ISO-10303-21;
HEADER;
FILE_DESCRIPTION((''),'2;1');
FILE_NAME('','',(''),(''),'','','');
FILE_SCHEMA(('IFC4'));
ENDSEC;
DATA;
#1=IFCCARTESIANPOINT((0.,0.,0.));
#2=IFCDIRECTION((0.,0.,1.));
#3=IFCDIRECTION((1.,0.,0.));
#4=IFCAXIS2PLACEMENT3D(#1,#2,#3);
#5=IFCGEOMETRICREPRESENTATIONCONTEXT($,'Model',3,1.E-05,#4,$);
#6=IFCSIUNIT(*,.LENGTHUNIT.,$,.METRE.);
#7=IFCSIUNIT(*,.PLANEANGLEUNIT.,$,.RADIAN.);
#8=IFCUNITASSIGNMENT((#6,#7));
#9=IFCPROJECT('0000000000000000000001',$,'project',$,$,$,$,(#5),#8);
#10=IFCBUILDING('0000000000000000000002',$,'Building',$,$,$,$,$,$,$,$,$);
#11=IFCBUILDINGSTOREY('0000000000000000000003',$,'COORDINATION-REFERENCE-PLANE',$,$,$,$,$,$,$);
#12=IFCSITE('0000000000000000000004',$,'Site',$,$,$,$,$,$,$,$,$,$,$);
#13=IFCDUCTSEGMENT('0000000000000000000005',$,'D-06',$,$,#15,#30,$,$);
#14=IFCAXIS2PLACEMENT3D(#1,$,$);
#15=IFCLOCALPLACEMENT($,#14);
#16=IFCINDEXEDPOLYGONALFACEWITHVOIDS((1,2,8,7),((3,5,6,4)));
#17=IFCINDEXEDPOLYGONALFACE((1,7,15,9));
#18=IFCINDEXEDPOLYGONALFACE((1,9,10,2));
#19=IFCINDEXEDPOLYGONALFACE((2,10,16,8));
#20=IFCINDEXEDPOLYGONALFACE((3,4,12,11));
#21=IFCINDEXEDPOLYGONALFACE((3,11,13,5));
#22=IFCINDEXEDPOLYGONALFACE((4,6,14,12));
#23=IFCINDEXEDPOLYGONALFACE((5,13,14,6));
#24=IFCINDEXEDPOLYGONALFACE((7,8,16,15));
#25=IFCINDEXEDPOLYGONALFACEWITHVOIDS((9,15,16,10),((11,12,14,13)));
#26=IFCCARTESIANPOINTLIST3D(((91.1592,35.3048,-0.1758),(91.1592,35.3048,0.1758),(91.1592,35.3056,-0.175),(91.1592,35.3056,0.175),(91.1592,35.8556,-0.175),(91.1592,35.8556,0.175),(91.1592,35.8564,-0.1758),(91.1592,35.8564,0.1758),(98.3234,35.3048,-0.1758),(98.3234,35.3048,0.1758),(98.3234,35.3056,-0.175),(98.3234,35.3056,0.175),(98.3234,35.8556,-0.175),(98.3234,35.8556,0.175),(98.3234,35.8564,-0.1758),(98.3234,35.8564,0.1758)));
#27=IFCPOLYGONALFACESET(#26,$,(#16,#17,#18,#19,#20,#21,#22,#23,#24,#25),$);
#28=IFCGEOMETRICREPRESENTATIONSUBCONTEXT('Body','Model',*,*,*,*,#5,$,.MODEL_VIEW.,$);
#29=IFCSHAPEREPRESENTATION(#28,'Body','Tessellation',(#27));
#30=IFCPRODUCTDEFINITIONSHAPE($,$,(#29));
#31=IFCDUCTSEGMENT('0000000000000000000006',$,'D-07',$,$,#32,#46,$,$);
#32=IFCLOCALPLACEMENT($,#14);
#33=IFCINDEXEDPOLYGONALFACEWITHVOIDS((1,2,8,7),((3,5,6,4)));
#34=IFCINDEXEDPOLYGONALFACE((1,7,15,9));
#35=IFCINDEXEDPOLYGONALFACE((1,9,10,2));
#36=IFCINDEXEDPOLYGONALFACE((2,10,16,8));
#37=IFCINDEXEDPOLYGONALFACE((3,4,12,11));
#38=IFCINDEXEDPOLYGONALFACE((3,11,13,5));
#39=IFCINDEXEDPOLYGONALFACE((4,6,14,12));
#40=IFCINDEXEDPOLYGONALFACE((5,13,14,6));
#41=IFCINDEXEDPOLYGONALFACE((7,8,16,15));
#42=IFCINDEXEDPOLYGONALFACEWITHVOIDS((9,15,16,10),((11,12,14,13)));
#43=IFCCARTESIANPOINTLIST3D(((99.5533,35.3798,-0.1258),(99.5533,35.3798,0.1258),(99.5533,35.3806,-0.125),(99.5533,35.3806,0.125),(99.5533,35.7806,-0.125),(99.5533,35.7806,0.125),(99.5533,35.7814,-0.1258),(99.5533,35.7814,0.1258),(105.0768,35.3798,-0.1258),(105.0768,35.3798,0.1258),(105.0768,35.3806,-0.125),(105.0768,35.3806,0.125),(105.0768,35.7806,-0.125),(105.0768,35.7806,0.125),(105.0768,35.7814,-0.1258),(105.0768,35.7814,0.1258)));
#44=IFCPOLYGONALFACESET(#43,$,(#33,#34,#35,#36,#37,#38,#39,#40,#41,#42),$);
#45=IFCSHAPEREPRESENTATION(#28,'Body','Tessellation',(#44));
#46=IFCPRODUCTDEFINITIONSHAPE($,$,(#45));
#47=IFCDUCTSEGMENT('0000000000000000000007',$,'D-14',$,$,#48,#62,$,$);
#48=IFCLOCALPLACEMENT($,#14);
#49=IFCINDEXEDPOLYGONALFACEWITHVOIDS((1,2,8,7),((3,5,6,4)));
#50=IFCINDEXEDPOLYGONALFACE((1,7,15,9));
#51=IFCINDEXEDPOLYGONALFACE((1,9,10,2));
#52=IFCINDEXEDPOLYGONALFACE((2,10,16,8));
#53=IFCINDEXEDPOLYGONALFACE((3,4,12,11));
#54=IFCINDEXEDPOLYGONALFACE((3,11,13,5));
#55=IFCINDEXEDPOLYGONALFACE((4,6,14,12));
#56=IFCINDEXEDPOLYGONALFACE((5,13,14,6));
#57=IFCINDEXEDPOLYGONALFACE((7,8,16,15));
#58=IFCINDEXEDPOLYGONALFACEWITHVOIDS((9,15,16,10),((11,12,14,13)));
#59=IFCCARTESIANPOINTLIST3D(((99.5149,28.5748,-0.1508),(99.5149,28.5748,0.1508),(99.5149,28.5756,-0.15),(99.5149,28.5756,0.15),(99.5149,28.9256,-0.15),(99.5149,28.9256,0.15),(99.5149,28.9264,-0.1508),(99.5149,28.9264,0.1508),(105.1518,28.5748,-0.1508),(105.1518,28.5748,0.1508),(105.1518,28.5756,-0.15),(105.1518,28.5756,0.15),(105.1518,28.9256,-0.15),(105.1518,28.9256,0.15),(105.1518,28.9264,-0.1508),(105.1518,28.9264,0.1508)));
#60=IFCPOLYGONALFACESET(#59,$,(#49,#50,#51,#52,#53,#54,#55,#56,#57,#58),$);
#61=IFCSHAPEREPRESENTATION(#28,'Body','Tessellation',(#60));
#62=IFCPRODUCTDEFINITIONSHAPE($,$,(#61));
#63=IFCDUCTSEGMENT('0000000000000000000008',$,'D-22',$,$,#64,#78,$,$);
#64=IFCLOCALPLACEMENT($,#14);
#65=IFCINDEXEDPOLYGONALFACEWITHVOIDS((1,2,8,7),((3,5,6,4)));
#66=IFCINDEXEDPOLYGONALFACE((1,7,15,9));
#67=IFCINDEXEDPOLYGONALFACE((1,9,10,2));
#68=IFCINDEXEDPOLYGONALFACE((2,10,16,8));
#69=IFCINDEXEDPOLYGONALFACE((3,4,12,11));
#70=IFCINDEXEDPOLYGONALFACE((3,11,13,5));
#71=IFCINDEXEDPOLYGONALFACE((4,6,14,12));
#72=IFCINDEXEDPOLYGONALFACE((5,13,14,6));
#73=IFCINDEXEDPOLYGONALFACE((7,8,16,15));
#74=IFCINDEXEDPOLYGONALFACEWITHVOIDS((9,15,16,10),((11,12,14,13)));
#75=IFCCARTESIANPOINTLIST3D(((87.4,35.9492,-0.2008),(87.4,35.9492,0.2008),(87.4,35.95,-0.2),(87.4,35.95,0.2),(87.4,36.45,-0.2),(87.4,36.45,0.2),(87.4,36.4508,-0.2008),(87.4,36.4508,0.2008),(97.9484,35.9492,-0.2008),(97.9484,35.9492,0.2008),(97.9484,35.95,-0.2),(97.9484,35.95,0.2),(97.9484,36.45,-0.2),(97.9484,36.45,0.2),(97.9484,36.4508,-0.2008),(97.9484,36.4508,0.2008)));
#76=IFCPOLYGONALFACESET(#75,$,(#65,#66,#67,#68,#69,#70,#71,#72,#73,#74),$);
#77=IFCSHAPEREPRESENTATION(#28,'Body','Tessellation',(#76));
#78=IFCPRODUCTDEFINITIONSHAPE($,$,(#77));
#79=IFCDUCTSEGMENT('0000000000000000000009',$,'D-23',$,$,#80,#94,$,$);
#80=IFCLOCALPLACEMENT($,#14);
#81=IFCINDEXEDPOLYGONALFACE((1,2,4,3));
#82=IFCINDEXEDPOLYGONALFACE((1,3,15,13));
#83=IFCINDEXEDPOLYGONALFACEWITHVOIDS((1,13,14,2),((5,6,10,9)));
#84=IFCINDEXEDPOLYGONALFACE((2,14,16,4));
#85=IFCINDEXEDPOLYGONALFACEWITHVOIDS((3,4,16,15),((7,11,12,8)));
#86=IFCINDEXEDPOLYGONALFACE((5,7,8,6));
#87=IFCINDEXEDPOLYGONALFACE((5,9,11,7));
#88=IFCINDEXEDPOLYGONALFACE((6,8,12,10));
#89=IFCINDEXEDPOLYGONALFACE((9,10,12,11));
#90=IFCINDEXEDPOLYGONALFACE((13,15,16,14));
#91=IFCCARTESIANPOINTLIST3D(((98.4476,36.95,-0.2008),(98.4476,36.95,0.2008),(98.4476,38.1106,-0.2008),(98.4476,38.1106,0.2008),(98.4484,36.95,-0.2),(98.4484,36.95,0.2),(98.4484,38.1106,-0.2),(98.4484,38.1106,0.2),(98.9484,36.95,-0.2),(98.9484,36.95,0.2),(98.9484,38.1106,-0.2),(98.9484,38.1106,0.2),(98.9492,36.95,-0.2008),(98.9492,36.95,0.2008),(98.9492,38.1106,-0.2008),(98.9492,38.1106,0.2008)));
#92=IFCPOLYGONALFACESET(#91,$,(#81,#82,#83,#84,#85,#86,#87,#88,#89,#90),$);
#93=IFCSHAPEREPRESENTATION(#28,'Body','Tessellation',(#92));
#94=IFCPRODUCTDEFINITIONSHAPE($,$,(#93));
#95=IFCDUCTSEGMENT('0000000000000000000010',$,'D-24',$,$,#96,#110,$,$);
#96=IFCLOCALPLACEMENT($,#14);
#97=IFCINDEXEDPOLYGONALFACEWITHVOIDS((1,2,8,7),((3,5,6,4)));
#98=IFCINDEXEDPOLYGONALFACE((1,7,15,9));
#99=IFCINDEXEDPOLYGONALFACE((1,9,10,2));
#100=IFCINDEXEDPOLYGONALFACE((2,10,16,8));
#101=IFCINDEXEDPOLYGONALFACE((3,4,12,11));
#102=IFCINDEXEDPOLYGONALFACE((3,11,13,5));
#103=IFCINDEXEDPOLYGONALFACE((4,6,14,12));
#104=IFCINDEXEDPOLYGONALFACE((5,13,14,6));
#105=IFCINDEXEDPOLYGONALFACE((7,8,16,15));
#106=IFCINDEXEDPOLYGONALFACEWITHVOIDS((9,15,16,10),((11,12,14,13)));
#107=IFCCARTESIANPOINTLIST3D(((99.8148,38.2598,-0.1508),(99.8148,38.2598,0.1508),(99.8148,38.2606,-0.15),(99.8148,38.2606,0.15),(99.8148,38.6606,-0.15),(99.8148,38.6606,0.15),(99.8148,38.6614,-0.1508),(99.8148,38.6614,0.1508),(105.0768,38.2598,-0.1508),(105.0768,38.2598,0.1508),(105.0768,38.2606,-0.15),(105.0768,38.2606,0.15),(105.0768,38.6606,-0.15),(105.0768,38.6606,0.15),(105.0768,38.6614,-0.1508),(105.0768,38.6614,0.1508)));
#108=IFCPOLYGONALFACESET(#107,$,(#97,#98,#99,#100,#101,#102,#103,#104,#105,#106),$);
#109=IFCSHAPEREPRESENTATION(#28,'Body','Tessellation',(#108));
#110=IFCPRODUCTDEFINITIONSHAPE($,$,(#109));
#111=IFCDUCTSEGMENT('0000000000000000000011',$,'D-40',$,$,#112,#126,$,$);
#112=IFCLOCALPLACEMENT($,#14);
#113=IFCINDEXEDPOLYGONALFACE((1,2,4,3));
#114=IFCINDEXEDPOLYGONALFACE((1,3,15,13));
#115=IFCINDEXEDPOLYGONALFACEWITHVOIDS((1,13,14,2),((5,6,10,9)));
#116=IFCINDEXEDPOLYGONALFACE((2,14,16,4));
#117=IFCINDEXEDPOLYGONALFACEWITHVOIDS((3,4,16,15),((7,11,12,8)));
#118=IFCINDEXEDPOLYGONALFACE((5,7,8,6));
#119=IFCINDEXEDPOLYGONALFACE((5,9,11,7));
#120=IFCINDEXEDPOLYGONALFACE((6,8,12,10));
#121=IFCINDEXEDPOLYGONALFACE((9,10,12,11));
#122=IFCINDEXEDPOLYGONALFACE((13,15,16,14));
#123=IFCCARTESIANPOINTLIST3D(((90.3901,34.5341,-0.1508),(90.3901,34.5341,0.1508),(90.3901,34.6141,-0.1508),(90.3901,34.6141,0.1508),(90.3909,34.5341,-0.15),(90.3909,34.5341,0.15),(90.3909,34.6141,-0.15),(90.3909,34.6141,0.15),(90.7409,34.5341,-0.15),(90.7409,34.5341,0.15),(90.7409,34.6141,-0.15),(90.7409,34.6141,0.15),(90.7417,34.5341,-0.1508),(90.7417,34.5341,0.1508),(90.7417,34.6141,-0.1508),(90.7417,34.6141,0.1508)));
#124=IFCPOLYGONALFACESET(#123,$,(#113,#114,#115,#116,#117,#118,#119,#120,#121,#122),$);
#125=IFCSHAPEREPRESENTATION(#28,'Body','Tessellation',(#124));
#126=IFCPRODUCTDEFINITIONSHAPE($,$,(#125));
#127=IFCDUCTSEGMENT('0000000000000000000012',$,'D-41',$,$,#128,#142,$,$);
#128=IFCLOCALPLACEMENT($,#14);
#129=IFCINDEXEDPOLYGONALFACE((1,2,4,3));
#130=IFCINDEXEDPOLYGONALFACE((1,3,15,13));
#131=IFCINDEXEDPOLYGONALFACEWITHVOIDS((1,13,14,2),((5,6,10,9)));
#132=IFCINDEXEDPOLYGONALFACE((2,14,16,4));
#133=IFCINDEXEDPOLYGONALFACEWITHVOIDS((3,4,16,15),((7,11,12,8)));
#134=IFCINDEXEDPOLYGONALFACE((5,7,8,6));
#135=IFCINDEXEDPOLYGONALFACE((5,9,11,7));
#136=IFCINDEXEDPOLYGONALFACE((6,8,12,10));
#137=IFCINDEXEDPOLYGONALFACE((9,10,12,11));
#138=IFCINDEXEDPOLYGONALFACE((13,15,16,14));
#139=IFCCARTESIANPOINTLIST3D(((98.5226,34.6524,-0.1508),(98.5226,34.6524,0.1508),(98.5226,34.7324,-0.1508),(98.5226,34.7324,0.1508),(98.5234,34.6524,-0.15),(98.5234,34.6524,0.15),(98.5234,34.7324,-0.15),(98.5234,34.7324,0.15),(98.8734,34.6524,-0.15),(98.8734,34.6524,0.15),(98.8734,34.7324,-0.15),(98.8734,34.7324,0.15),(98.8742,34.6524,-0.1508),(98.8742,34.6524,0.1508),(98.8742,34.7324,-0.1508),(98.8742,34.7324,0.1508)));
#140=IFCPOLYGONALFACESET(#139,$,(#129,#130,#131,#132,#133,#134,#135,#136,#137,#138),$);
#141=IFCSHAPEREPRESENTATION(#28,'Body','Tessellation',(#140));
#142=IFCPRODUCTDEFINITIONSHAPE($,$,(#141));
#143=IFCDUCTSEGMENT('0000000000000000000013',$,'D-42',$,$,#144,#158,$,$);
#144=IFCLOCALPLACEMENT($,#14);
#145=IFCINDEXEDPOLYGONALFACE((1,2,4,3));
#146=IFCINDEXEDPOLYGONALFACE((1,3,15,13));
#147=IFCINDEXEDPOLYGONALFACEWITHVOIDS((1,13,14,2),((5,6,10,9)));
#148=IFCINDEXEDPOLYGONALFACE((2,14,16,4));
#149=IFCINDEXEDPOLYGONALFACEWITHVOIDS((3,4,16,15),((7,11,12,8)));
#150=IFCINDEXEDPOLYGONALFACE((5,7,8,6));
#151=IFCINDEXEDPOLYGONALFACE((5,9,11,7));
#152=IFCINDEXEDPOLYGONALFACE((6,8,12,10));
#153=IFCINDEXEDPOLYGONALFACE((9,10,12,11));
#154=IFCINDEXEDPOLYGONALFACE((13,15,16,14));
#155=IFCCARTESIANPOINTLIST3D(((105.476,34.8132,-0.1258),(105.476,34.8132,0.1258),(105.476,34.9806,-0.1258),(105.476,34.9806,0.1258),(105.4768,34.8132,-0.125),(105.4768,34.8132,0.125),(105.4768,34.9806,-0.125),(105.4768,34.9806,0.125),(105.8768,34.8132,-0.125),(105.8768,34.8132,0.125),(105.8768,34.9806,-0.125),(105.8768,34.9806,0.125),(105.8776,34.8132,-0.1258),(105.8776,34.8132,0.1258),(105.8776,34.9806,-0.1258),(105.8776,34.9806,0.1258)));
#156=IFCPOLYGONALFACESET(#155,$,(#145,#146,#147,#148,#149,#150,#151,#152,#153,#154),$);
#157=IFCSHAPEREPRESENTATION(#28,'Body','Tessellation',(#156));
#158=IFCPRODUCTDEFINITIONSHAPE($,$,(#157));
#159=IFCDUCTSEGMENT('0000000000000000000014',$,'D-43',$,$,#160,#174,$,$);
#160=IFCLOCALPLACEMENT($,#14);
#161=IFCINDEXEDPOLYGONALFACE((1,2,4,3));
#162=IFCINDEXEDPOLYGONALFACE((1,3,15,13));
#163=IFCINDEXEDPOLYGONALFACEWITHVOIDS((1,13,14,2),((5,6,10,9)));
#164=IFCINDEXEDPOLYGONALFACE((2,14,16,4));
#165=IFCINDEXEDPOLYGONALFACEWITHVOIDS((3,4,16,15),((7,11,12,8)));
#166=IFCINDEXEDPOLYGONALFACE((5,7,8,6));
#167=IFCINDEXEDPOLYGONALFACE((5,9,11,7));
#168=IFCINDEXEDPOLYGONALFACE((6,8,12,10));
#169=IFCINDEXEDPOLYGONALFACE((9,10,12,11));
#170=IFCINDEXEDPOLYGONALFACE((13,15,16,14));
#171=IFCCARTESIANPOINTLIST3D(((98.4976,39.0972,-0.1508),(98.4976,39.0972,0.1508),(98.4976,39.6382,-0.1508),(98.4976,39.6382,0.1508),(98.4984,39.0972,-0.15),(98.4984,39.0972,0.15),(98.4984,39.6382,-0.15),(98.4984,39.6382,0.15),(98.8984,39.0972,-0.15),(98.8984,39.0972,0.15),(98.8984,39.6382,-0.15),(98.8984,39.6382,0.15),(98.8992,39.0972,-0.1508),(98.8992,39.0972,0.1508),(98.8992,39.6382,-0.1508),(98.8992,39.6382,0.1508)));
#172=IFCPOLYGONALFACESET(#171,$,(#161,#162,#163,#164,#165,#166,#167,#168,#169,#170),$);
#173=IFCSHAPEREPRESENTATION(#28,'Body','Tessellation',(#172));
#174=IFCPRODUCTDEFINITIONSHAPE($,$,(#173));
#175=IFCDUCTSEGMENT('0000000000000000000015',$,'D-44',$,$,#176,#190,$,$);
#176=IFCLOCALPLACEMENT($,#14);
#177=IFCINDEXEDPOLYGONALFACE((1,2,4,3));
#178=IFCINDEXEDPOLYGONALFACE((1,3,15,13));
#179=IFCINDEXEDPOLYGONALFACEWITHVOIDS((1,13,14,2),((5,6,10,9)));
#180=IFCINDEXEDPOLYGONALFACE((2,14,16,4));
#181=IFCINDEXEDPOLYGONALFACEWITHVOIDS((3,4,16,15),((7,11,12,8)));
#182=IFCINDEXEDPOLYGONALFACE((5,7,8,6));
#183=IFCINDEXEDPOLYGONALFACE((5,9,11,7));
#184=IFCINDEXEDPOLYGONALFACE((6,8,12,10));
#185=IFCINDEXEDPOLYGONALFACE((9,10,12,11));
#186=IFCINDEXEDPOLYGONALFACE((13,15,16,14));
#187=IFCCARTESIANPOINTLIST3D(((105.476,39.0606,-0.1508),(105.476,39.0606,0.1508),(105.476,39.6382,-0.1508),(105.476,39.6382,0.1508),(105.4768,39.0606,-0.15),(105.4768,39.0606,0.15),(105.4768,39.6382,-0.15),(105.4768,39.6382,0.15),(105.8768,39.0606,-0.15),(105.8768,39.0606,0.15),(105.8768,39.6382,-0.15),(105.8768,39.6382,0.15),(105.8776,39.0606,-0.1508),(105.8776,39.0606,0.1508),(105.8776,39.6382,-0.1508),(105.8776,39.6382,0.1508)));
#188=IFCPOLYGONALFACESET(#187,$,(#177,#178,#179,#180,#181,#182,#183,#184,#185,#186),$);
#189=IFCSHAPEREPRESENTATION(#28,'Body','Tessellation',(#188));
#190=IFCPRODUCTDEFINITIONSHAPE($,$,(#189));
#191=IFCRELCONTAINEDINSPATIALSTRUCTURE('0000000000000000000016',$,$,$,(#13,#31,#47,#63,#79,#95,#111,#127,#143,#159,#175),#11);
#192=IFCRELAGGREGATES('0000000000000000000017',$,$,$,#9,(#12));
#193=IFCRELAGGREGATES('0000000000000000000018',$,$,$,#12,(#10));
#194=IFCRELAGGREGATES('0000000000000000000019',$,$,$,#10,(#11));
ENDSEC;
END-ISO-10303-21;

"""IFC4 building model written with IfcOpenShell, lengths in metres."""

from ifc_helpers import new_model, si_unit, frame, origin, origin_with_axes, place, context, subcontext, project, spatial, hollow_rectangle, extrude, element, save


model = new_model("IFC4")

# Units and contexts
model_context = context("Model", 3, precision=1e-05, world=origin_with_axes())
body_context_1 = subcontext(model_context, "Body", "Model", "MODEL_VIEW")
ifc_project = project(units=[si_unit("LENGTHUNIT", "METRE"), si_unit("PLANEANGLEUNIT", "RADIAN")], contexts=[model_context])

# Site, building, storey
site = spatial("IfcSite", under=ifc_project, Name="Site")
building = spatial("IfcBuilding", under=site, Name="Building")
storey = spatial("IfcBuildingStorey", under=building, Name="COORDINATION-REFERENCE-PLANE")

# Duct segments
duct_segment_1_placement = place(None, frame((91.1592, 35.5806, 0.0), z_axis=(1.0, 0.0, 0.0), x_axis=(0.0, 1.0, 0.0)))
element("IfcDuctSegment", 1, at=duct_segment_1_placement, inside=storey, Name="D-06", context=body_context_1, shape_type="SweptSolid", body=[
    extrude(hollow_rectangle(XDim=0.5516, YDim=0.3516, WallThickness=0.0008), origin(), (0.0, 0.0, 1.0), 7.1642),
])
duct_segment_2_placement = place(None, frame((99.5533, 35.5806, 0.0), z_axis=(1.0, 0.0, 0.0), x_axis=(0.0, 1.0, 0.0)))
element("IfcDuctSegment", 2, at=duct_segment_2_placement, inside=storey, Name="D-07", context=body_context_1, shape_type="SweptSolid", body=[
    extrude(hollow_rectangle(XDim=0.4016, YDim=0.2516, WallThickness=0.0008), origin(), (0.0, 0.0, 1.0), 5.5234),
])
duct_segment_3_placement = place(None, frame((99.5149, 28.7506, 0.0), z_axis=(1.0, 0.0, 0.0), x_axis=(0.0, 1.0, 0.0)))
element("IfcDuctSegment", 3, at=duct_segment_3_placement, inside=storey, Name="D-14", context=body_context_1, shape_type="SweptSolid", body=[
    extrude(hollow_rectangle(XDim=0.3516, YDim=0.3016, WallThickness=0.0008), origin(), (0.0, 0.0, 1.0), 5.6369),
])
duct_segment_4_placement = place(None, frame((87.4, 36.2, 0.0), z_axis=(1.0, 0.0, 0.0), x_axis=(0.0, 1.0, 0.0)))
element("IfcDuctSegment", 4, at=duct_segment_4_placement, inside=storey, Name="D-22", context=body_context_1, shape_type="SweptSolid", body=[
    extrude(hollow_rectangle(XDim=0.5016, YDim=0.4016, WallThickness=0.0008), origin(), (0.0, 0.0, 1.0), 10.5484),
])
duct_segment_5_placement = place(None, frame((98.6984, 36.95, 0.0), z_axis=(0.0, 1.0, 0.0), x_axis=(1.0, 0.0, 0.0)))
element("IfcDuctSegment", 5, at=duct_segment_5_placement, inside=storey, Name="D-23", context=body_context_1, shape_type="SweptSolid", body=[
    extrude(hollow_rectangle(XDim=0.5016, YDim=0.4016, WallThickness=0.0008), origin(), (0.0, 0.0, 1.0), 1.1606),
])
duct_segment_6_placement = place(None, frame((99.8148, 38.4606, 0.0), z_axis=(1.0, 0.0, 0.0), x_axis=(0.0, 1.0, 0.0)))
element("IfcDuctSegment", 6, at=duct_segment_6_placement, inside=storey, Name="D-24", context=body_context_1, shape_type="SweptSolid", body=[
    extrude(hollow_rectangle(XDim=0.4016, YDim=0.3016, WallThickness=0.0008), origin(), (0.0, 0.0, 1.0), 5.2619),
])
for number, where, z_axis, x_axis, name in (
    (7, (90.5659, 34.5341, 0.0), (0.0, 1.0, 0.0), (1.0, 0.0, 0.0), "D-40"),
    (8, (98.6984, 34.6524, 0.0), (0.0, 1.0, 0.0), (1.0, 0.0, 0.0), "D-41"),
):
    element("IfcDuctSegment", number, at=place(None, frame(where, z_axis=z_axis, x_axis=x_axis)), inside=storey, Name=name, context=body_context_1, shape_type="SweptSolid", body=[
        extrude(hollow_rectangle(XDim=0.3516, YDim=0.3016, WallThickness=0.0008), origin(), (0.0, 0.0, 1.0), 0.08),
    ])
duct_segment_7_placement = place(None, frame((105.6768, 34.8132, 0.0), z_axis=(0.0, 1.0, 0.0), x_axis=(1.0, 0.0, 0.0)))
element("IfcDuctSegment", 9, at=duct_segment_7_placement, inside=storey, Name="D-42", context=body_context_1, shape_type="SweptSolid", body=[
    extrude(hollow_rectangle(XDim=0.4016, YDim=0.2516, WallThickness=0.0008), origin(), (0.0, 0.0, 1.0), 0.1673),
])
duct_segment_8_placement = place(None, frame((98.6984, 39.0972, 0.0), z_axis=(0.0, 1.0, 0.0), x_axis=(1.0, 0.0, 0.0)))
element("IfcDuctSegment", 10, at=duct_segment_8_placement, inside=storey, Name="D-43", context=body_context_1, shape_type="SweptSolid", body=[
    extrude(hollow_rectangle(XDim=0.4016, YDim=0.3016, WallThickness=0.0008), origin(), (0.0, 0.0, 1.0), 0.541),
])
duct_segment_9_placement = place(None, frame((105.6768, 39.0606, 0.0), z_axis=(0.0, 1.0, 0.0), x_axis=(1.0, 0.0, 0.0)))
element("IfcDuctSegment", 11, at=duct_segment_9_placement, inside=storey, Name="D-44", context=body_context_1, shape_type="SweptSolid", body=[
    extrude(hollow_rectangle(XDim=0.4016, YDim=0.3016, WallThickness=0.0008), origin(), (0.0, 0.0, 1.0), 0.5776),
])

save(model, "model.ifc")
